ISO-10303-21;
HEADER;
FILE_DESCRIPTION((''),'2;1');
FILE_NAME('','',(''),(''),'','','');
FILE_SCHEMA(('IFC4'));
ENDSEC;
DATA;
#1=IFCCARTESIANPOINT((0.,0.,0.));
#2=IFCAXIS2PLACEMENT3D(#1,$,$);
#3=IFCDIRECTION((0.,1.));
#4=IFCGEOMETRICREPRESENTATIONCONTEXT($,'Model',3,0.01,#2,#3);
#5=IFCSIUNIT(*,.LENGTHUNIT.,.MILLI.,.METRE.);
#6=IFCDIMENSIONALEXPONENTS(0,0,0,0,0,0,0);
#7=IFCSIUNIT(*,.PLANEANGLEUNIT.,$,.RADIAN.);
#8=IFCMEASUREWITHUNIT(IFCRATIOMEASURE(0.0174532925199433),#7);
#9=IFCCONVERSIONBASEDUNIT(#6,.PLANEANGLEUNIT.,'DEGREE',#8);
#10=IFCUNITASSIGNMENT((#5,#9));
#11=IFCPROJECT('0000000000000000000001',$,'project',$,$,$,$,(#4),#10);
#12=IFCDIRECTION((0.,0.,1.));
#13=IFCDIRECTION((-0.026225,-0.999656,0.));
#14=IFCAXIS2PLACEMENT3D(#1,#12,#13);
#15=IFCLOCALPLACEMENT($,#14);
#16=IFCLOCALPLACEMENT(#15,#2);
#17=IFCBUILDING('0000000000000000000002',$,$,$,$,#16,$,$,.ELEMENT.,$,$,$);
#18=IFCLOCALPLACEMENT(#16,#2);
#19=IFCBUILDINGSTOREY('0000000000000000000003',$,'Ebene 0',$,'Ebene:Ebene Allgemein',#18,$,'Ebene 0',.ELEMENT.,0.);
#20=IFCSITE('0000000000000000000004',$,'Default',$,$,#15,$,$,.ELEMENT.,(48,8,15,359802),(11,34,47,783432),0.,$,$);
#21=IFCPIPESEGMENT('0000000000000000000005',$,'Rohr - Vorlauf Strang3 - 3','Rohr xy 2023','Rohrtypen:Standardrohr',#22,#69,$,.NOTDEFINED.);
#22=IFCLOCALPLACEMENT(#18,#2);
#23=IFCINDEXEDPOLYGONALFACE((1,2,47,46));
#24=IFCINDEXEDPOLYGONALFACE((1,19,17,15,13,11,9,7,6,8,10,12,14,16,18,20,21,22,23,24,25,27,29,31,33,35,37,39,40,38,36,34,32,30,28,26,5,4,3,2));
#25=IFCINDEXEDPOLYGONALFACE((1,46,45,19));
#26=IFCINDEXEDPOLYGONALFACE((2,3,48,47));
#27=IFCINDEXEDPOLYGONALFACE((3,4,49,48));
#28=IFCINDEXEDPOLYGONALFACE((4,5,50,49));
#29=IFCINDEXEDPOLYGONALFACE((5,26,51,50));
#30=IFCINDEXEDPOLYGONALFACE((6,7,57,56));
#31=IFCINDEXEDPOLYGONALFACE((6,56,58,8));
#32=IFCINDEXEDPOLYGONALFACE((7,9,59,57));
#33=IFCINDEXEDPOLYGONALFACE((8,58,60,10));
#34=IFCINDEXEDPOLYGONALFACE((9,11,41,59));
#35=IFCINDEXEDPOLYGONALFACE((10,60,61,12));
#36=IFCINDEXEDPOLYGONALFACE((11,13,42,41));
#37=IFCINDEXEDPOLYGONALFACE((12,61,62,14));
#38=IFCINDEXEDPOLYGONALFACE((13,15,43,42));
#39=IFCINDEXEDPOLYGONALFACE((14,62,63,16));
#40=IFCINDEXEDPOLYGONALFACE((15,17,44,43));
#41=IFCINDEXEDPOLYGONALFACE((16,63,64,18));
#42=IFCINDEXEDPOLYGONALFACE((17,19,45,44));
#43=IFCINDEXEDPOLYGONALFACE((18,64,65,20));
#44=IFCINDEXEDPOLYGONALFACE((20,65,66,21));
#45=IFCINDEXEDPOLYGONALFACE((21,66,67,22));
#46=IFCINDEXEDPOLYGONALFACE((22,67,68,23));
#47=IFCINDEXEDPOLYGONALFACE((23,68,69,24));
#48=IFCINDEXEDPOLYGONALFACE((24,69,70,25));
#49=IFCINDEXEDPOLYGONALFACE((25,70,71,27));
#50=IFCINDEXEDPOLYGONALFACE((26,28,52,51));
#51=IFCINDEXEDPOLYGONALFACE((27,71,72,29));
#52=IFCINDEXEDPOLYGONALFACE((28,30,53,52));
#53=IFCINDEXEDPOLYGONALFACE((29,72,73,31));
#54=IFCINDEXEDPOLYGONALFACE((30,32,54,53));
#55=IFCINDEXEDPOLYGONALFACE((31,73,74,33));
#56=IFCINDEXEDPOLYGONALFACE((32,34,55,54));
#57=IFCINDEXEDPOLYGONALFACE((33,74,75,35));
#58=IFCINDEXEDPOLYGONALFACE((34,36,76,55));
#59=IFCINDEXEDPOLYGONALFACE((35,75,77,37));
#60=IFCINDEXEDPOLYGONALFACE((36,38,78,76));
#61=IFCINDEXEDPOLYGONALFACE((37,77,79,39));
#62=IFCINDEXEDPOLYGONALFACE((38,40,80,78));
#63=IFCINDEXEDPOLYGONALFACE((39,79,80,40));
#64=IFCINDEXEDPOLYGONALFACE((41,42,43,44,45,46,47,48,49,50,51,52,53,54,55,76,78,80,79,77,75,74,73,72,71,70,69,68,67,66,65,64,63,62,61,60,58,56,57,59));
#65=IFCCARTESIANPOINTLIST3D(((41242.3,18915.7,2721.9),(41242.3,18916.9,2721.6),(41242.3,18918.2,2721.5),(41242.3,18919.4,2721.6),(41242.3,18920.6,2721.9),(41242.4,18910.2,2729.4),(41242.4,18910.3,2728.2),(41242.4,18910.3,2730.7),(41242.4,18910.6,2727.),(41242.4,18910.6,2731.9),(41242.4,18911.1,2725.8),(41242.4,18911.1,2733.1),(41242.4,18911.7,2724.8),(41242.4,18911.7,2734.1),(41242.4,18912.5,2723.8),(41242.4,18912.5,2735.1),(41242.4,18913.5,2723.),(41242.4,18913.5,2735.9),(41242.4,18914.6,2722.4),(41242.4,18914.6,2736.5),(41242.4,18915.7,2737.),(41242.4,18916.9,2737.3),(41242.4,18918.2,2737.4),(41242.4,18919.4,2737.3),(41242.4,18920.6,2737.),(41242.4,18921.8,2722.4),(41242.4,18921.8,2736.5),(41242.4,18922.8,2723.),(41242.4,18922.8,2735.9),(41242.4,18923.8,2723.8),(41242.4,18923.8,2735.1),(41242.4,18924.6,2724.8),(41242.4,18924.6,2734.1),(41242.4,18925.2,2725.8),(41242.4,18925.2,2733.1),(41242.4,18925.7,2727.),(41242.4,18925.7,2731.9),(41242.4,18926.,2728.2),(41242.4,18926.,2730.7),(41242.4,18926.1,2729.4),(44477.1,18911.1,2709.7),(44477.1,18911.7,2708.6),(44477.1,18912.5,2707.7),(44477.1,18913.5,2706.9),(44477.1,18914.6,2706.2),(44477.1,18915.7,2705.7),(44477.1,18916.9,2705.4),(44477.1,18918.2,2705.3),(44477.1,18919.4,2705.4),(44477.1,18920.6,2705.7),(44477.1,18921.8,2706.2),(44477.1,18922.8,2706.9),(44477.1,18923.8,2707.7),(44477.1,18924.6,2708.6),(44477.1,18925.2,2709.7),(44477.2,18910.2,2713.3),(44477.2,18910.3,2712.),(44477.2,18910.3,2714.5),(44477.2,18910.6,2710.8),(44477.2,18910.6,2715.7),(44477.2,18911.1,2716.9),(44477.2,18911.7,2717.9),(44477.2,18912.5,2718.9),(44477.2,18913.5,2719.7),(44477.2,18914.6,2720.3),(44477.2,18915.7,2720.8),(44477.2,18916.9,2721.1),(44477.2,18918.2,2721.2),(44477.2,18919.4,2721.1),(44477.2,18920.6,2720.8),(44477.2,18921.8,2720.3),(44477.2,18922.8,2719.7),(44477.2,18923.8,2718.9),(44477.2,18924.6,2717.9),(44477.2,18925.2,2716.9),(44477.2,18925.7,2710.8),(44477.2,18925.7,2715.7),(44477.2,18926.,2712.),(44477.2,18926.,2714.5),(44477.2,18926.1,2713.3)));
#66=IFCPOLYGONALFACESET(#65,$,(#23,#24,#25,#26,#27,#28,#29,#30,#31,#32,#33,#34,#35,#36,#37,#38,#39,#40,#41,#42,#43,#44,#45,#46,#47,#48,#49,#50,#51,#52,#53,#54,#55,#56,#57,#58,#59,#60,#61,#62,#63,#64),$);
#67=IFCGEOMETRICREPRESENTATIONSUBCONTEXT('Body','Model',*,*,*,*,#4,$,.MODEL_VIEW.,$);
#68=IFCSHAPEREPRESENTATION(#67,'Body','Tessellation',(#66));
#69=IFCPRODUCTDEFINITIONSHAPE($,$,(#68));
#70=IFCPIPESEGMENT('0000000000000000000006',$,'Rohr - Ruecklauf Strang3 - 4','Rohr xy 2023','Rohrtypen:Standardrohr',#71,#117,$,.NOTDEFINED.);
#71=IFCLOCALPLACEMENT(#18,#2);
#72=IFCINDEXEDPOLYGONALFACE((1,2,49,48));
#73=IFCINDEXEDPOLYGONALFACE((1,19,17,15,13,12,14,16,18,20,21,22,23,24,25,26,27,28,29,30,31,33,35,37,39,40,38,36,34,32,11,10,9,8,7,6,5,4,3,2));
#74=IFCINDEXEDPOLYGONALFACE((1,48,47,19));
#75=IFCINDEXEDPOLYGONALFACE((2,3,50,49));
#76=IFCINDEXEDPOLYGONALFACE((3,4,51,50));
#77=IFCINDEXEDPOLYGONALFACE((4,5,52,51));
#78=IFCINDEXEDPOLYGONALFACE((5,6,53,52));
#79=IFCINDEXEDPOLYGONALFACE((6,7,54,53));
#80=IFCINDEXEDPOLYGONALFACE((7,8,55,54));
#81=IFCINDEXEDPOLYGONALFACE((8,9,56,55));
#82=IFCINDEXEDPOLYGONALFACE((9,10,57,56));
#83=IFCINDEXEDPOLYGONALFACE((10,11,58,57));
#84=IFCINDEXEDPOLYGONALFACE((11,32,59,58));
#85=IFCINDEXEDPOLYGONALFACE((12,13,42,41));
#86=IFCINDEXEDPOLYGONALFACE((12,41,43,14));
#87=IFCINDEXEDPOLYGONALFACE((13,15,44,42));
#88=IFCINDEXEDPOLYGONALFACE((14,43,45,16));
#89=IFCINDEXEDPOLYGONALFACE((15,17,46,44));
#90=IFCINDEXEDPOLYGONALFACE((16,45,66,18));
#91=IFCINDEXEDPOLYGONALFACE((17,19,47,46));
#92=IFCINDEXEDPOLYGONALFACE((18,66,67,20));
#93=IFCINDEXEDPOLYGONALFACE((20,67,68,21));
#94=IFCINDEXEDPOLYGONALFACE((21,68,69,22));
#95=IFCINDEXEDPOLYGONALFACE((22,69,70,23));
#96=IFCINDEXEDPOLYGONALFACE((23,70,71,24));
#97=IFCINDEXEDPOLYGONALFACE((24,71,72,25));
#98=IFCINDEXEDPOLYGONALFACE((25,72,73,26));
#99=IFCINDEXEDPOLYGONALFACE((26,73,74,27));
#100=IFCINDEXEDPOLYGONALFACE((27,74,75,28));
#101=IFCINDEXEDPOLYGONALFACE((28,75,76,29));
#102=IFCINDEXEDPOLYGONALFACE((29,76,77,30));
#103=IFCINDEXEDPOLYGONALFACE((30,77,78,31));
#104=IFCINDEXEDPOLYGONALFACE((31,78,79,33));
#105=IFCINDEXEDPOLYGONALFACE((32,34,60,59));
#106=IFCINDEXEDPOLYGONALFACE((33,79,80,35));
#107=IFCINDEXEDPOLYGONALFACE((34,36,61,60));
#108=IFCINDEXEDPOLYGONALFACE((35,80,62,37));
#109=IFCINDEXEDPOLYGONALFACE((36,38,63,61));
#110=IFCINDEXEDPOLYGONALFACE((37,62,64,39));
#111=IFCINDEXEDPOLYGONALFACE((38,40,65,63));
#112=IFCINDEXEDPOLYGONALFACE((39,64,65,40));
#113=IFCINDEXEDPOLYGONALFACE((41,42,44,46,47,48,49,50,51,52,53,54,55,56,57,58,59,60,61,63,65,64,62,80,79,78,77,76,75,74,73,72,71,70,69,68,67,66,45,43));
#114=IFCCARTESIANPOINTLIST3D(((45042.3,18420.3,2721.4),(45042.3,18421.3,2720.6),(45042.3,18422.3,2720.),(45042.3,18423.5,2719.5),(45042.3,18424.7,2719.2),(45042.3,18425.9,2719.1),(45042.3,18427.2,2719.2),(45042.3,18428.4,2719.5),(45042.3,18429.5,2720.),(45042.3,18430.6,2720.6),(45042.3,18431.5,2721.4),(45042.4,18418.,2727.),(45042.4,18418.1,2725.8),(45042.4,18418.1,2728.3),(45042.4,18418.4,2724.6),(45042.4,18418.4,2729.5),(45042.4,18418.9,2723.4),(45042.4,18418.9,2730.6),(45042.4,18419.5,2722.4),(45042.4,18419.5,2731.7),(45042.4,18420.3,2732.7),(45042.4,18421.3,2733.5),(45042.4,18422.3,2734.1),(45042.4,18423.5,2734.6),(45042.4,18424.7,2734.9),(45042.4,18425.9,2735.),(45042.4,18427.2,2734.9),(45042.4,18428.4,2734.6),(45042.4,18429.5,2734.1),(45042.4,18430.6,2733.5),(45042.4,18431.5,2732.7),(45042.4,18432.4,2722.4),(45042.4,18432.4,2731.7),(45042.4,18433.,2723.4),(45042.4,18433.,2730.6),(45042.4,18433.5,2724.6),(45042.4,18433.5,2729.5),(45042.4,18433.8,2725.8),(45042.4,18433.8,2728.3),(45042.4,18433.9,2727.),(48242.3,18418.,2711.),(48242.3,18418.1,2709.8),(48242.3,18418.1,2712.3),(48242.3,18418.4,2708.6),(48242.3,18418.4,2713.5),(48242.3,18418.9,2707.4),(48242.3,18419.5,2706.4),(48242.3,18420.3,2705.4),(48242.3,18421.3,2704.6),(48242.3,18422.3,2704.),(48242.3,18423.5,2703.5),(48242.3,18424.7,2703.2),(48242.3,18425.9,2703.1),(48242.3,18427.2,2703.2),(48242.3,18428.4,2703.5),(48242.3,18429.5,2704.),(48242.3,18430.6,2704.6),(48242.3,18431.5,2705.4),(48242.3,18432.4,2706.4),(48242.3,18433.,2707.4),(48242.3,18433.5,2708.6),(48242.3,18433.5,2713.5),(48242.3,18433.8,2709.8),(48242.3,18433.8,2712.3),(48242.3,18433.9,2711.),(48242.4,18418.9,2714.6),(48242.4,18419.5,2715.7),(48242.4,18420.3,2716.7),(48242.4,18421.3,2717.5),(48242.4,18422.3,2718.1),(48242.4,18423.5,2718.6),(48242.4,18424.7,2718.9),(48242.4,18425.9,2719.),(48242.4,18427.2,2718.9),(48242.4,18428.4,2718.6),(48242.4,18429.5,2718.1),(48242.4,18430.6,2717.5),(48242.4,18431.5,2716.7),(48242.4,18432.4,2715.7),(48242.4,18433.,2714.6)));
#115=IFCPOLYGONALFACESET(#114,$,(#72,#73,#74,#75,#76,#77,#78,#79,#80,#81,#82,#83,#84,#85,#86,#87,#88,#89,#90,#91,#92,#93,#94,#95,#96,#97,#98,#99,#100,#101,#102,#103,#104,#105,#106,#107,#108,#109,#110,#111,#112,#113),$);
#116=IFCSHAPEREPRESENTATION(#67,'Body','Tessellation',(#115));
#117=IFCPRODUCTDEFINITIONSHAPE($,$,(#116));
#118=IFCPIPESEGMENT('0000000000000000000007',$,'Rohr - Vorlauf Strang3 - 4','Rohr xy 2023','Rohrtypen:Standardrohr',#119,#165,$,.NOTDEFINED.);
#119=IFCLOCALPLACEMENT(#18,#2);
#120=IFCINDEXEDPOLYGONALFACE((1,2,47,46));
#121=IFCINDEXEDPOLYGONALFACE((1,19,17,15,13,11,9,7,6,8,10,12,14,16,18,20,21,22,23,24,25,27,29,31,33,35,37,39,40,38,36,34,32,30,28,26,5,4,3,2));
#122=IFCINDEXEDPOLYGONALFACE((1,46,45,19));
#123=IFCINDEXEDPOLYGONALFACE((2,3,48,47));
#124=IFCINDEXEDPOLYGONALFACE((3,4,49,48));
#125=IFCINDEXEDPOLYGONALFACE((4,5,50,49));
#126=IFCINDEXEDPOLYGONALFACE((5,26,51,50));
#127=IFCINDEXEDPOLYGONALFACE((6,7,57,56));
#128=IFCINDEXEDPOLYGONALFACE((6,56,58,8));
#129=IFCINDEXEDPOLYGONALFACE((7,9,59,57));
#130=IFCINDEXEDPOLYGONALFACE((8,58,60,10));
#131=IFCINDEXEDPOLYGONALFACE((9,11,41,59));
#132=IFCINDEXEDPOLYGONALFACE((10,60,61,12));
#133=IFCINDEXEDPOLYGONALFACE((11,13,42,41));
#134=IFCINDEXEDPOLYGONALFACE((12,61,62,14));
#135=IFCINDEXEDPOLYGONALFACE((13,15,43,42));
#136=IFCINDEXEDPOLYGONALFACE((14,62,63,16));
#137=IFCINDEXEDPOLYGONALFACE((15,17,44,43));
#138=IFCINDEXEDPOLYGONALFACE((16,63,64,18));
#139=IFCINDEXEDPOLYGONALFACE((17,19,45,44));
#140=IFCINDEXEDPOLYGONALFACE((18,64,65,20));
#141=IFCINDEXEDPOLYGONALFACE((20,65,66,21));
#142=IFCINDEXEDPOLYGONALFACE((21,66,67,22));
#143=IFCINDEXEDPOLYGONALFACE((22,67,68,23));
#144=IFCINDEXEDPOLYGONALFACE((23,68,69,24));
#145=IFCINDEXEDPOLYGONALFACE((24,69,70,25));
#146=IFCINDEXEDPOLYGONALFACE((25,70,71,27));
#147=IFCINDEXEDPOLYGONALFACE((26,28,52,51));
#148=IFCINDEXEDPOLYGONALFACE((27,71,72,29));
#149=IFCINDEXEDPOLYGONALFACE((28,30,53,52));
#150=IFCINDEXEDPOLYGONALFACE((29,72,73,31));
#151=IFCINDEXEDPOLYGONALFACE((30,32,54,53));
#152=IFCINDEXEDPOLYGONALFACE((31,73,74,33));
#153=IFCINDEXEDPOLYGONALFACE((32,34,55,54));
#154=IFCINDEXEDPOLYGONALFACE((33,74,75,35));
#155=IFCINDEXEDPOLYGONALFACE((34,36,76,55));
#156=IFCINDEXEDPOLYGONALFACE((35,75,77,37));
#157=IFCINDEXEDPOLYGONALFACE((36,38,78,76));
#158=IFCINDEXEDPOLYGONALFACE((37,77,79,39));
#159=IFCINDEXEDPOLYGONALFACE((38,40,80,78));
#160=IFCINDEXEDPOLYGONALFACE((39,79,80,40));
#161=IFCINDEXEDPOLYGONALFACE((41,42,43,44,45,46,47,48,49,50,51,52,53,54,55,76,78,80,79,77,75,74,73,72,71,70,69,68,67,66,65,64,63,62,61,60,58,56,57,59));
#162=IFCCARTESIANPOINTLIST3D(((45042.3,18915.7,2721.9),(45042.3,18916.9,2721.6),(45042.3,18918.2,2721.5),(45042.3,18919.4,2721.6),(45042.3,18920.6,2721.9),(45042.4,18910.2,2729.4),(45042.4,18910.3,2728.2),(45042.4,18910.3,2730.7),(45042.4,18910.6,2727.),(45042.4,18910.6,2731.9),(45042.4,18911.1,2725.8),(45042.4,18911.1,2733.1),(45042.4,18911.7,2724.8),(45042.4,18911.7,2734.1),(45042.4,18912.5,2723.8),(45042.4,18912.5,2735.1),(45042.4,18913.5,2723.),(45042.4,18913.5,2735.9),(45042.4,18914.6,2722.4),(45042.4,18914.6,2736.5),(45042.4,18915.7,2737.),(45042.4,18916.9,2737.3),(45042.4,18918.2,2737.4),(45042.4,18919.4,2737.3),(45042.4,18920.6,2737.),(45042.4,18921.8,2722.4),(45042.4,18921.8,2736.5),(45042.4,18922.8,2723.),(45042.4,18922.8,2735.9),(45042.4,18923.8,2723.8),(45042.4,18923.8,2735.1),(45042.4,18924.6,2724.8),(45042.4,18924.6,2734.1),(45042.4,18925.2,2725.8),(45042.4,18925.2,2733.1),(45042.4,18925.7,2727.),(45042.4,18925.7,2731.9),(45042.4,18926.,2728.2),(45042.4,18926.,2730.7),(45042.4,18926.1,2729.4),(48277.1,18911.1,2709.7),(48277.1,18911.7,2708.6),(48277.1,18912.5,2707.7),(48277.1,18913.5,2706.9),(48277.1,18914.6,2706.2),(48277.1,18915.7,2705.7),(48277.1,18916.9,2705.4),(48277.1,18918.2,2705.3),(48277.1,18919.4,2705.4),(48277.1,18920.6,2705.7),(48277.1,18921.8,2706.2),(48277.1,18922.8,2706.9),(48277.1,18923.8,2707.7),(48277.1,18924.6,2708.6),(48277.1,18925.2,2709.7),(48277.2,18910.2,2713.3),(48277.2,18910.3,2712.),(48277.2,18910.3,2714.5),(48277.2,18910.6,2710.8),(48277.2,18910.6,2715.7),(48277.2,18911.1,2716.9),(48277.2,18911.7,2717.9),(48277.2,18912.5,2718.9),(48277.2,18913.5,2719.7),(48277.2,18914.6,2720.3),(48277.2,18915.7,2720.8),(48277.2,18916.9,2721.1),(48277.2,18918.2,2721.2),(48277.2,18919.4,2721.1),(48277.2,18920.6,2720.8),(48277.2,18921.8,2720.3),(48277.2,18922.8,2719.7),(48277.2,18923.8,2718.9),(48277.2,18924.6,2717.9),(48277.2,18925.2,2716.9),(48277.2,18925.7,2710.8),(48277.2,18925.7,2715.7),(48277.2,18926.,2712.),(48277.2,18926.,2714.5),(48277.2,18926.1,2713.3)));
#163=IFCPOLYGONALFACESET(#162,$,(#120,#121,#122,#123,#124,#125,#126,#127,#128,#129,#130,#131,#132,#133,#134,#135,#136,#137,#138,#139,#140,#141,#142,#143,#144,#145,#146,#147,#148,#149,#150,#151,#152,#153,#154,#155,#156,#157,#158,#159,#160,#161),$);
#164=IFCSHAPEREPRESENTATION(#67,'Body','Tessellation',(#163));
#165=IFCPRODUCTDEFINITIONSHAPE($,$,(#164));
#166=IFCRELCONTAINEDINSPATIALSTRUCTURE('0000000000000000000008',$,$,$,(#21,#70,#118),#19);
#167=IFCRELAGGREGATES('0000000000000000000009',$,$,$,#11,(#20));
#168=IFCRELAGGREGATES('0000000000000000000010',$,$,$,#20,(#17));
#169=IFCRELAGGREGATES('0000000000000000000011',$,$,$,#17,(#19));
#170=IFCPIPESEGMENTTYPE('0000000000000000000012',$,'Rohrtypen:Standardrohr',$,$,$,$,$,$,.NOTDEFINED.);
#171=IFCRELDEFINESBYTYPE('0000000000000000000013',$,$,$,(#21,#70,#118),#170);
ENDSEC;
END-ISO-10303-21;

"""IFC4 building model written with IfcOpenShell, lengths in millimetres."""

from ifc_helpers import new_model, entity, si_unit, converted_unit, direction, frame, origin, place, context, subcontext, project, spatial, indexed_curve, outline, extrude, type_object, element, save


model = new_model("IFC4")

# Units and contexts
model_context = context("Model", 3, precision=0.01, world=origin(), true_north=direction((0.0, 1.0)))
body_context = subcontext(model_context, "Body", "Model", "MODEL_VIEW")
ifc_project = project(units=[si_unit("LENGTHUNIT", "METRE", prefix="MILLI"), converted_unit("PLANEANGLEUNIT", "DEGREE", entity("IfcRatioMeasure", 0.0174532925199433), si_unit("PLANEANGLEUNIT", "RADIAN"), dimensions=[0, 0, 0, 0, 0, 0, 0])], contexts=[model_context])

# Site, building, storey
site_placement = place(None, frame((0.0, 0.0, 0.0), z_axis=(0.0, 0.0, 1.0), x_axis=(-0.026225, -0.999656, 0.0)))
site = spatial("IfcSite", under=ifc_project, at=site_placement, Name="Default", CompositionType="ELEMENT", RefLatitude=(48, 8, 15, 359802), RefLongitude=(11, 34, 47, 783432), RefElevation=0.0)
building_placement = place(site_placement, origin())
building = spatial("IfcBuilding", under=site, at=building_placement, CompositionType="ELEMENT")
storey_placement = place(building_placement, origin())
storey = spatial("IfcBuildingStorey", under=building, at=storey_placement, Name="Ebene 0", ObjectType="Ebene:Ebene Allgemein", LongName="Ebene 0", CompositionType="ELEMENT", Elevation=0.0)

# Pipe segments
pipe_segment_type = type_object("IfcPipeSegmentType", Name="Rohrtypen:Standardrohr", PredefinedType="NOTDEFINED")
pipe_segment_1_placement = place(storey_placement, origin())
element("IfcPipeSegment", 1, at=pipe_segment_1_placement, inside=storey, type_object=pipe_segment_type, Name="Rohr - Vorlauf Strang3 - 3", Description="Rohr xy 2023", ObjectType="Rohrtypen:Standardrohr", PredefinedType="NOTDEFINED", context=body_context, shape_type="SweptSolid", body=[
    extrude(outline(indexed_curve([(7.9, 0.0), (7.8, 1.2), (7.6, 2.5), (7.1, 3.6), (6.4, 4.7), (5.6, 5.6), (4.7, 6.4), (3.6, 7.1), (2.5, 7.6), (1.2, 7.8), (0.0, 7.9), (-1.2, 7.8), (-2.5, 7.6), (-3.6, 7.1), (-4.7, 6.4), (-5.6, 5.6), (-6.4, 4.7), (-7.1, 3.6), (-7.6, 2.5), (-7.8, 1.2), (-7.9, 0.0), (-7.8, -1.2), (-7.6, -2.5), (-7.1, -3.6), (-6.4, -4.7), (-5.6, -5.6), (-4.7, -6.4), (-3.6, -7.1), (-2.5, -7.6), (-1.2, -7.8), (0.0, -7.9), (1.2, -7.8), (2.5, -7.6), (3.6, -7.1), (4.7, -6.4), (5.6, -5.6), (6.4, -4.7), (7.1, -3.6), (7.6, -2.5), (7.8, -1.2), (7.9, 0.0)], self_intersect=False)), frame((44477.2, 18918.2, 2713.3), z_axis=(-0.999988, 0.0, 0.005), x_axis=(0.0, 1.0, 0.0)), (0.0, 0.0, 1.0), 3234.8),
])
pipe_segment_2_placement = place(storey_placement, origin())
element("IfcPipeSegment", 2, at=pipe_segment_2_placement, inside=storey, type_object=pipe_segment_type, Name="Rohr - Ruecklauf Strang3 - 4", Description="Rohr xy 2023", ObjectType="Rohrtypen:Standardrohr", PredefinedType="NOTDEFINED", context=body_context, shape_type="SweptSolid", body=[
    extrude(outline(indexed_curve([(7.9, 0.0), (7.8, 1.2), (7.6, 2.5), (7.1, 3.6), (6.4, 4.7), (5.6, 5.6), (4.7, 6.4), (3.6, 7.1), (2.5, 7.6), (1.2, 7.8), (0.0, 7.9), (-1.2, 7.8), (-2.5, 7.6), (-3.6, 7.1), (-4.7, 6.4), (-5.6, 5.6), (-6.4, 4.7), (-7.1, 3.6), (-7.6, 2.5), (-7.8, 1.2), (-7.9, 0.0), (-7.8, -1.2), (-7.6, -2.5), (-7.1, -3.6), (-6.4, -4.7), (-5.6, -5.6), (-4.7, -6.4), (-3.6, -7.1), (-2.5, -7.6), (-1.2, -7.8), (0.0, -7.9), (1.2, -7.8), (2.5, -7.6), (3.6, -7.1), (4.7, -6.4), (5.6, -5.6), (6.4, -4.7), (7.1, -3.6), (7.6, -2.5), (7.8, -1.2), (7.9, 0.0)], self_intersect=False)), frame((48242.3, 18425.9, 2711.0), z_axis=(-0.999988, 0.0, 0.005), x_axis=(0.0, 1.0, 0.0)), (0.0, 0.0, 1.0), 3200.0),
])
pipe_segment_3_placement = place(storey_placement, origin())
element("IfcPipeSegment", 3, at=pipe_segment_3_placement, inside=storey, type_object=pipe_segment_type, Name="Rohr - Vorlauf Strang3 - 4", Description="Rohr xy 2023", ObjectType="Rohrtypen:Standardrohr", PredefinedType="NOTDEFINED", context=body_context, shape_type="SweptSolid", body=[
    extrude(outline(indexed_curve([(7.9, 0.0), (7.8, 1.2), (7.6, 2.5), (7.1, 3.6), (6.4, 4.7), (5.6, 5.6), (4.7, 6.4), (3.6, 7.1), (2.5, 7.6), (1.2, 7.8), (0.0, 7.9), (-1.2, 7.8), (-2.5, 7.6), (-3.6, 7.1), (-4.7, 6.4), (-5.6, 5.6), (-6.4, 4.7), (-7.1, 3.6), (-7.6, 2.5), (-7.8, 1.2), (-7.9, 0.0), (-7.8, -1.2), (-7.6, -2.5), (-7.1, -3.6), (-6.4, -4.7), (-5.6, -5.6), (-4.7, -6.4), (-3.6, -7.1), (-2.5, -7.6), (-1.2, -7.8), (0.0, -7.9), (1.2, -7.8), (2.5, -7.6), (3.6, -7.1), (4.7, -6.4), (5.6, -5.6), (6.4, -4.7), (7.1, -3.6), (7.6, -2.5), (7.8, -1.2), (7.9, 0.0)], self_intersect=False)), frame((48277.2, 18918.2, 2713.3), z_axis=(-0.999988, 0.0, 0.005), x_axis=(0.0, 1.0, 0.0)), (0.0, 0.0, 1.0), 3234.8),
])

save(model, "model.ifc")
